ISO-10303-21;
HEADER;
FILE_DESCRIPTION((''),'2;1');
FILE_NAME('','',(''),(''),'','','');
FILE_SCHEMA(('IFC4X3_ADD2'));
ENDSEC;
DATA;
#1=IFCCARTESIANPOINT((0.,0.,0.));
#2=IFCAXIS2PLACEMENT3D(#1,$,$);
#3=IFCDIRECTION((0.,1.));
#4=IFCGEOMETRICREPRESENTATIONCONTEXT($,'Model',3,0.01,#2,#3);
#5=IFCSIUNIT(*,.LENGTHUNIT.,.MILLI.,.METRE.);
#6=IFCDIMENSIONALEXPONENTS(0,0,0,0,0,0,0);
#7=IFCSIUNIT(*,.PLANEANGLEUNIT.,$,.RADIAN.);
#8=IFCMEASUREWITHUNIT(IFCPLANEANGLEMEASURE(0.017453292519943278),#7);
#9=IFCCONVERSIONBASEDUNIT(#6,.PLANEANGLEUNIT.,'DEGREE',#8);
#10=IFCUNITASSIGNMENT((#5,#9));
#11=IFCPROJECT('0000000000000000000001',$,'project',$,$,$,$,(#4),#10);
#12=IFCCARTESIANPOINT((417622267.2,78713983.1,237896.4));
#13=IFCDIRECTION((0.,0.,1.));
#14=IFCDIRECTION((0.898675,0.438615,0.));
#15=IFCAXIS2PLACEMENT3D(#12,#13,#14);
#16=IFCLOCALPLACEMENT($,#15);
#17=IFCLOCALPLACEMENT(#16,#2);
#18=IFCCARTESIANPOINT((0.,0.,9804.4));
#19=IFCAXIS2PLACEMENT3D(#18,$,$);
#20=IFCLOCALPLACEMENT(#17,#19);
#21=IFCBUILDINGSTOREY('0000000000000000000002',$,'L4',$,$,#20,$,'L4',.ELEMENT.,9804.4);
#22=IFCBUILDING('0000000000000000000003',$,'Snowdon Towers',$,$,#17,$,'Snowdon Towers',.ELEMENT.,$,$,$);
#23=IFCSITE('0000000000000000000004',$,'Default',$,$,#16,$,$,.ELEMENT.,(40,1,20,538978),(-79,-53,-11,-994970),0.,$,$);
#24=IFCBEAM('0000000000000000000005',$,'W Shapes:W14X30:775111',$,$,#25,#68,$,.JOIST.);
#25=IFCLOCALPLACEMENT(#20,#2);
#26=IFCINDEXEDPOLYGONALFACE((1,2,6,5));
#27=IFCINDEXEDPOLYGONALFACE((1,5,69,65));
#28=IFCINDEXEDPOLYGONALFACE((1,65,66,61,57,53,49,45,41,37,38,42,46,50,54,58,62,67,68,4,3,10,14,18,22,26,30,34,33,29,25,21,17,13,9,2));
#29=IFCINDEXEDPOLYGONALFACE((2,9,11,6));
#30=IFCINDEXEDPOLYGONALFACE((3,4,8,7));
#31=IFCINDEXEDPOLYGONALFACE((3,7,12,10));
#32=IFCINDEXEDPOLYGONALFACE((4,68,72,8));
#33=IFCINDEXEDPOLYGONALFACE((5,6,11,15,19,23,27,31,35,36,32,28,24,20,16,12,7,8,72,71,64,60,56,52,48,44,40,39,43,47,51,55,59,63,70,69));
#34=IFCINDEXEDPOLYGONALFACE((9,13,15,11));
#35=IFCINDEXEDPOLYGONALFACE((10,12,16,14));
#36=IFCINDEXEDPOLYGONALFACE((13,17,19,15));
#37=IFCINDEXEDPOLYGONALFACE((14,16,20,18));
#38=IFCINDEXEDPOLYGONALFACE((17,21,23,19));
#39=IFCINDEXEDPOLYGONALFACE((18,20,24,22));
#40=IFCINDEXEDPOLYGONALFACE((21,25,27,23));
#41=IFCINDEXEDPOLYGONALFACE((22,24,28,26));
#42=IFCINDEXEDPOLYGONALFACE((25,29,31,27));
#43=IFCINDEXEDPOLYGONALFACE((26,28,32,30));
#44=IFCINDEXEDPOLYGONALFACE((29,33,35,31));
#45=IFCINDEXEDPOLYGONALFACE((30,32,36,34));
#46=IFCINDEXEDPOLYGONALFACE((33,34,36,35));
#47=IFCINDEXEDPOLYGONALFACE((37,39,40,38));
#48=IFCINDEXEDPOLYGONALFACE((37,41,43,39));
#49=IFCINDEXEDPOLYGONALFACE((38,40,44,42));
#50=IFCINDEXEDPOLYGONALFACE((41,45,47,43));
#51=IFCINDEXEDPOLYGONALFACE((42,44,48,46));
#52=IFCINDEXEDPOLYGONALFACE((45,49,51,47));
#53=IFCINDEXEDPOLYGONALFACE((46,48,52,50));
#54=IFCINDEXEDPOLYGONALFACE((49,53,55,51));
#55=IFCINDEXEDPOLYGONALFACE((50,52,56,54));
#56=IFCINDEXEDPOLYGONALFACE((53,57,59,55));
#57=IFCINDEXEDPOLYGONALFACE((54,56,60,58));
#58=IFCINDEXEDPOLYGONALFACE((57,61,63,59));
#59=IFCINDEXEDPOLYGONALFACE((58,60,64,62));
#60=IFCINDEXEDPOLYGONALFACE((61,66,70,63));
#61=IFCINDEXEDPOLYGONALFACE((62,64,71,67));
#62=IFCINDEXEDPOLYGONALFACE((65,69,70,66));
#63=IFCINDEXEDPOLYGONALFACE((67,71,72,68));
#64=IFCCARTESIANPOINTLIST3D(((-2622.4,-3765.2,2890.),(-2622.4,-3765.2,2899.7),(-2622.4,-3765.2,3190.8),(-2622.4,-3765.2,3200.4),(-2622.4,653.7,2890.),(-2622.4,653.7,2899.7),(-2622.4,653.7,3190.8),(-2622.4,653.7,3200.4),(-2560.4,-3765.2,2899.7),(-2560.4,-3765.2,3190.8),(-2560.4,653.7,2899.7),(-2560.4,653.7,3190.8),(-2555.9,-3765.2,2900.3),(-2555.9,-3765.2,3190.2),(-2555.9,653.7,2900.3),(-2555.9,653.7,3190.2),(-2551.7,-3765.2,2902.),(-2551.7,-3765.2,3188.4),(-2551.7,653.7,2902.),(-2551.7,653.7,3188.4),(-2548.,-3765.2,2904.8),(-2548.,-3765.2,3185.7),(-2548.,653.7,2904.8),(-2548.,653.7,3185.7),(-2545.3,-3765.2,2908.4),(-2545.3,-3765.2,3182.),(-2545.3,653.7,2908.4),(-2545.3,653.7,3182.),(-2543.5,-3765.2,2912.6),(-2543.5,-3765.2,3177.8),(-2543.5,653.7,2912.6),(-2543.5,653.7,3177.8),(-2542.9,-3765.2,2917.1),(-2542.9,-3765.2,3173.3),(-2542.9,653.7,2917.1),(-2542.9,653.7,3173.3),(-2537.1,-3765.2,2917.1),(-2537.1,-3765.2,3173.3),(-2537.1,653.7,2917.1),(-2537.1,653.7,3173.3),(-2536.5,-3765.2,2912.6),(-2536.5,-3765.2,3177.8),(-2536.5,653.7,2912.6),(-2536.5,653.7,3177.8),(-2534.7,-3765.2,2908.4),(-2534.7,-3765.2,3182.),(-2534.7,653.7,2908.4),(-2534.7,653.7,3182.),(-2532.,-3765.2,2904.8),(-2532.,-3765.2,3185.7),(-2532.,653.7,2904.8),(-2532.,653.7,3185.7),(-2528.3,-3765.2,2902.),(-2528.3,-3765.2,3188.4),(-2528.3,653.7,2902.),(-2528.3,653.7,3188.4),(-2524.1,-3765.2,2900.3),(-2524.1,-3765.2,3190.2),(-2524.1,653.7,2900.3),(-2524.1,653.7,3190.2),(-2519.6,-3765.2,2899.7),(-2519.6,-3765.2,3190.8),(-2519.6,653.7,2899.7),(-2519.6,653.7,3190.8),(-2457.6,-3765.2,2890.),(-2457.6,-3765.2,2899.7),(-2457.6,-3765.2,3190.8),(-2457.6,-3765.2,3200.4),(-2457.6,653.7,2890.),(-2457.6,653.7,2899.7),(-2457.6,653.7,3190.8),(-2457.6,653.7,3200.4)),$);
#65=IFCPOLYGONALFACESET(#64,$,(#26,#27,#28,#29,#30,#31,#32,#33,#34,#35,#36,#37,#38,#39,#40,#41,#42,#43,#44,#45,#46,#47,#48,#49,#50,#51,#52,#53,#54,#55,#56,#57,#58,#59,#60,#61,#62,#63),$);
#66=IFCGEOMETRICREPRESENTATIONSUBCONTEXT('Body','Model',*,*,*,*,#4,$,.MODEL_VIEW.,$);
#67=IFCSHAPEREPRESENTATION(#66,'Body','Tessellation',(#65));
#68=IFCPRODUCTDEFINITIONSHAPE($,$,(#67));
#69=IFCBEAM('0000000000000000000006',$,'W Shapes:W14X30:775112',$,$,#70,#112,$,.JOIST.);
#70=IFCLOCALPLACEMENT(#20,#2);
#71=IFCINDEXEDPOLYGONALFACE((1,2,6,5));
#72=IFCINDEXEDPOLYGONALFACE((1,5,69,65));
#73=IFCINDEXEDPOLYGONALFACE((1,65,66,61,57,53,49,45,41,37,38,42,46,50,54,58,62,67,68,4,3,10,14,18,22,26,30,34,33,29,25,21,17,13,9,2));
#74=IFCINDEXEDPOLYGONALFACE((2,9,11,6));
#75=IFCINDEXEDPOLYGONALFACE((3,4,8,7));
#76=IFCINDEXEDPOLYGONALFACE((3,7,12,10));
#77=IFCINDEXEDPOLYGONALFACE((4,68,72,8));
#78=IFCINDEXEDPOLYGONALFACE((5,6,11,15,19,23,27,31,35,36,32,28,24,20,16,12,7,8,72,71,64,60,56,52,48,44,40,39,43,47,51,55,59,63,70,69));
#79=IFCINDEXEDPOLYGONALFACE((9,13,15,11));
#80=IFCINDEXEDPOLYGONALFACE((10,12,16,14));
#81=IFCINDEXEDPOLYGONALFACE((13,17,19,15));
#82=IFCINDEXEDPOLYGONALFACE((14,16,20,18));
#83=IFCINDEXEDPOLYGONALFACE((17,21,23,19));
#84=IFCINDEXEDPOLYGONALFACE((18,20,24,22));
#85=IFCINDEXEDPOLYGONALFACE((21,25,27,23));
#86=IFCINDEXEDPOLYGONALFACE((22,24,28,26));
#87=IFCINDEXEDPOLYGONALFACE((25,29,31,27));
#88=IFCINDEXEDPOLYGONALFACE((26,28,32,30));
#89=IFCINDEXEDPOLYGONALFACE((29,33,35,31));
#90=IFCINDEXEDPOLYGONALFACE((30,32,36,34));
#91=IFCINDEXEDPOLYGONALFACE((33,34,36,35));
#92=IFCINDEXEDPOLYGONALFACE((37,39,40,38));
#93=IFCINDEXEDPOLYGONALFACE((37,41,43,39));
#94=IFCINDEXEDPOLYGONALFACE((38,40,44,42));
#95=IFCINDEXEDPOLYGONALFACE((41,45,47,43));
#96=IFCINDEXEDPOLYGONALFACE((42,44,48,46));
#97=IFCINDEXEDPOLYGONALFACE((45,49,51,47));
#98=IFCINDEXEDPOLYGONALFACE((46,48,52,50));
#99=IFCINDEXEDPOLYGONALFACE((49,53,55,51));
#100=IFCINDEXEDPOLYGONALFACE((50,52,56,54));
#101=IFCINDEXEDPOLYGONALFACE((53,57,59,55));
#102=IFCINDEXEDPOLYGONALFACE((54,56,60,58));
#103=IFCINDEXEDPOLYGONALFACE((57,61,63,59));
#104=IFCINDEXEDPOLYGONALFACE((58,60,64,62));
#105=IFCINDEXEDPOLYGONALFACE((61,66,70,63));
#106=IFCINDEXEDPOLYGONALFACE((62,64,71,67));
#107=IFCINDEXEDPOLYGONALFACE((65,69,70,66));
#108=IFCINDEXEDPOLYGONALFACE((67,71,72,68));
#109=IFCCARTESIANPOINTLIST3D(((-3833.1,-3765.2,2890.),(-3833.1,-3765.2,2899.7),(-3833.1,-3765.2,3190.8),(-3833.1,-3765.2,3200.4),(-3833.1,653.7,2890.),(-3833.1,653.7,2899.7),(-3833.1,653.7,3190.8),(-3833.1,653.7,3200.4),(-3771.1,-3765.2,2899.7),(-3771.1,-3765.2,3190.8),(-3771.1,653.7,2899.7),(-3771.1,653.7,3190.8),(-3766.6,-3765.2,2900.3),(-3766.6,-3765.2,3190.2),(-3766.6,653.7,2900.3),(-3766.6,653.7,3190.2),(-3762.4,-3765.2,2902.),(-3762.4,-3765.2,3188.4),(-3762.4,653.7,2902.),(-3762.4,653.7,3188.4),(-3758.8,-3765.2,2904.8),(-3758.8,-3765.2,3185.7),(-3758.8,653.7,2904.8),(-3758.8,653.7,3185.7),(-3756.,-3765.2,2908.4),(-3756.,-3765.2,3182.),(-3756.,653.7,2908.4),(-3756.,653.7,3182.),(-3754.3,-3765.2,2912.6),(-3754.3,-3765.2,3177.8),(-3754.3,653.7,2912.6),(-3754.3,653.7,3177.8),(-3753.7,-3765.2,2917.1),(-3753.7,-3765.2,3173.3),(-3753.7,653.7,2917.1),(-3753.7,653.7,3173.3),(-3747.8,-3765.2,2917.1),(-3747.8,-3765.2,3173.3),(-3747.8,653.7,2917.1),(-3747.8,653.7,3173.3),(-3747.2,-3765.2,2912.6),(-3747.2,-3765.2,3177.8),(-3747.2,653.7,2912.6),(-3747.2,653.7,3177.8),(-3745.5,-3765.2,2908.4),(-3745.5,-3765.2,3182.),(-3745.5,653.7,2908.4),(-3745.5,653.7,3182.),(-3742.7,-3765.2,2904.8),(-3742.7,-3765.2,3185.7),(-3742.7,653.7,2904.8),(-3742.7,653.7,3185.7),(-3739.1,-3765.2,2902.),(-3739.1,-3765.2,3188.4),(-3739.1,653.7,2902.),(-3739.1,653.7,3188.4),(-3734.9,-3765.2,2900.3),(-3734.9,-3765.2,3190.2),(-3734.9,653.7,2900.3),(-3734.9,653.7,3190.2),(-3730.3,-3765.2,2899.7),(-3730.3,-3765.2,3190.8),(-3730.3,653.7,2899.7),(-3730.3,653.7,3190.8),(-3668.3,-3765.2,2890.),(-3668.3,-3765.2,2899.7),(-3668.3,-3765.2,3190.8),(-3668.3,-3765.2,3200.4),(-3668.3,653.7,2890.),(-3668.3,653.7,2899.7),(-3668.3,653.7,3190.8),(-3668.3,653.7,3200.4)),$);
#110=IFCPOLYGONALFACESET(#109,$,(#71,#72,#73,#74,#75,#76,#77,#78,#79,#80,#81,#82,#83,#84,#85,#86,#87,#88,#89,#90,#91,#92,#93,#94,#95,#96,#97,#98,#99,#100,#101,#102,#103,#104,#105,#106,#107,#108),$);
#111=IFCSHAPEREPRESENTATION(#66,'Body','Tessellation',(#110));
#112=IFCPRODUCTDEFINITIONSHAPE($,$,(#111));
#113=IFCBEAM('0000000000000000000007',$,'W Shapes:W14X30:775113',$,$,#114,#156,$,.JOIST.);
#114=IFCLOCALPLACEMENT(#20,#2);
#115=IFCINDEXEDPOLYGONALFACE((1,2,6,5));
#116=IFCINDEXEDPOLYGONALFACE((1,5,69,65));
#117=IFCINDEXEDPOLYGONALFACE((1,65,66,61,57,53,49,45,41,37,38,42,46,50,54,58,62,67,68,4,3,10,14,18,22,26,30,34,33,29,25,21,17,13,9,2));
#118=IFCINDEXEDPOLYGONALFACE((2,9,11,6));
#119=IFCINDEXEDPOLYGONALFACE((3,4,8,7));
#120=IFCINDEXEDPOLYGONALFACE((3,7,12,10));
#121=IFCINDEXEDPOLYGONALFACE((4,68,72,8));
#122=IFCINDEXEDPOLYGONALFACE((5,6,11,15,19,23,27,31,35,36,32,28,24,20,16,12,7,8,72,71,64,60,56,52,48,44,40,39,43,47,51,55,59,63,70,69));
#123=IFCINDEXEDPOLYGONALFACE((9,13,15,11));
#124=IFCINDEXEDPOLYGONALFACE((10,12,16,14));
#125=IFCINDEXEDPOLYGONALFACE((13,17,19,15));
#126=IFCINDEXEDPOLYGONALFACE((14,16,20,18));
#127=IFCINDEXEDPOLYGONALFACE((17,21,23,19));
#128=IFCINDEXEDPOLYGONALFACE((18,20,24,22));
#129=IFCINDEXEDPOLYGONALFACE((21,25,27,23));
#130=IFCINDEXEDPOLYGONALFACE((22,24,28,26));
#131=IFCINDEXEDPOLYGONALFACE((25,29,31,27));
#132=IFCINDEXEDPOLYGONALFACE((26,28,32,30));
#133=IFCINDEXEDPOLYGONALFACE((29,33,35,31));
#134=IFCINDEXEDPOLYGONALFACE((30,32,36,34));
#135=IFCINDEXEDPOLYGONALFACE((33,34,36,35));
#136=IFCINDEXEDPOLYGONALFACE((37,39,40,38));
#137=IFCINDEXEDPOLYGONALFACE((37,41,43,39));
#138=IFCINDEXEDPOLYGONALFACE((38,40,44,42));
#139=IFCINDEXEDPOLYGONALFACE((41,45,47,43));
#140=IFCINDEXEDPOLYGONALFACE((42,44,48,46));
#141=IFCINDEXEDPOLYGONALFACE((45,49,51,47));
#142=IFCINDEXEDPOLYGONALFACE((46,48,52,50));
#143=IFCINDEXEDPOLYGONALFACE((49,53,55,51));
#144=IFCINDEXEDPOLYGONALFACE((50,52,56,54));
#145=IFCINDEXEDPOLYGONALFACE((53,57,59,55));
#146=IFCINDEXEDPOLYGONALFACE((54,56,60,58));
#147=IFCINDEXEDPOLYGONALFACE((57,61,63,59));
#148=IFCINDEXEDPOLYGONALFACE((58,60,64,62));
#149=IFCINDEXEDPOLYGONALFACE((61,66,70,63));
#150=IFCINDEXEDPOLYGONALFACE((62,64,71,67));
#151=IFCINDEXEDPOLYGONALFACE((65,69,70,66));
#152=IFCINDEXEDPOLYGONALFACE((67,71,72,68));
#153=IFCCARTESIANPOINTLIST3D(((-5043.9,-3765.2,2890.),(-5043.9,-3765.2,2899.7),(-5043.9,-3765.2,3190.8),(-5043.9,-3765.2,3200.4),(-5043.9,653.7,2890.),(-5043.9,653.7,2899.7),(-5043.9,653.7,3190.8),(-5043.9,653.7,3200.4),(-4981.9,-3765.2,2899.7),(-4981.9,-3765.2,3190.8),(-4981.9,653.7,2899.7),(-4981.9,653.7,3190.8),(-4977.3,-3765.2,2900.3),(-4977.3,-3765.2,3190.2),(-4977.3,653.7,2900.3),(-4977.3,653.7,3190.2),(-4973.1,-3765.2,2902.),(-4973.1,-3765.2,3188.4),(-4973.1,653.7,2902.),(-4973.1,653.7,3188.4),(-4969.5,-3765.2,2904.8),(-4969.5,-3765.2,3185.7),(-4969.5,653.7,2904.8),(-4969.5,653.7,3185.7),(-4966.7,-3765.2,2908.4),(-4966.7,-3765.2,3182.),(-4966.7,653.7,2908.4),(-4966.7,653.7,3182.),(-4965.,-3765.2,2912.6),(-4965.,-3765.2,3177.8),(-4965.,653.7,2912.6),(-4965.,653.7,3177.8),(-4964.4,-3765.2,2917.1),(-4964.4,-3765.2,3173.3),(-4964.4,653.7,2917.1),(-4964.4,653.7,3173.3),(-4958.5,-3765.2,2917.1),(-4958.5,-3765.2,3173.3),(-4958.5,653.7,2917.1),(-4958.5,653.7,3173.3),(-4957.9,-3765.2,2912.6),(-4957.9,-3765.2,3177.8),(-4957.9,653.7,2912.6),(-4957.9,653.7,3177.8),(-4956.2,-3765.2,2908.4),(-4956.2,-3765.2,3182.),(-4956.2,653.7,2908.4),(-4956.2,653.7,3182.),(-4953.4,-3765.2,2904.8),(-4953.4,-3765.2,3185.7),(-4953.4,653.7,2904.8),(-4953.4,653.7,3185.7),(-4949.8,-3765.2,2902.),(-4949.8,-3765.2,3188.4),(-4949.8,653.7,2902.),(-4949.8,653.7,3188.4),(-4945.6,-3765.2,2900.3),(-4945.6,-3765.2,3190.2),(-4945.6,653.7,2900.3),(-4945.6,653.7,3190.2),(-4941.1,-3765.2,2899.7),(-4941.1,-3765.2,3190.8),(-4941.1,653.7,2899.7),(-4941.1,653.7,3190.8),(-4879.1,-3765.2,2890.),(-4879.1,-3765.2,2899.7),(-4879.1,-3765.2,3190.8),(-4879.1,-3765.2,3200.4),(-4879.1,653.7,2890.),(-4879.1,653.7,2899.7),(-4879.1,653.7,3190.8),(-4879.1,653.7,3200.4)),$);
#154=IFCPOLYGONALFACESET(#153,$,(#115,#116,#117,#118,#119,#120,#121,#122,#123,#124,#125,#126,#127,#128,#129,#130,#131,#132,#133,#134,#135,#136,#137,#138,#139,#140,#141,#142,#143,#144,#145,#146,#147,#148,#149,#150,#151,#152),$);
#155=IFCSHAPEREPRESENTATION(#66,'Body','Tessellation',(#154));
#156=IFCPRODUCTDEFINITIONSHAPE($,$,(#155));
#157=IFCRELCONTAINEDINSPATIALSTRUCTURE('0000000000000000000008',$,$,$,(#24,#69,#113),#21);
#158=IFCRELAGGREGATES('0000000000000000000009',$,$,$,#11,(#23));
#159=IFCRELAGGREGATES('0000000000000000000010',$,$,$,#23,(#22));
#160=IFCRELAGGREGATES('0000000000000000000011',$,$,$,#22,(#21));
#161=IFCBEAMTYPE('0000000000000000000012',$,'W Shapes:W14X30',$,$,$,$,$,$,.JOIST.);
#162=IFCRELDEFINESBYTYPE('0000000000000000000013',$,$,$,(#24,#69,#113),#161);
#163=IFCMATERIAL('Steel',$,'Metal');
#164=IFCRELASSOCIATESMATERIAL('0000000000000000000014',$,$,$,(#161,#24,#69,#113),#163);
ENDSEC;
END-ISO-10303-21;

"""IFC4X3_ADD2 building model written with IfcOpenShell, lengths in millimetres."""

from ifc_helpers import new_model, entity, si_unit, converted_unit, direction, frame, frame_2d, origin, place, context, subcontext, project, spatial, polyline, circle_curve, parameter, trimmed, segment, composite_curve, outline, extrude, source, transform, mapped, material, material_profile, profile_set, profile_usage, type_object, type_shapes, element, save


model = new_model("IFC4X3_ADD2")

# Units and contexts
model_context = context("Model", 3, precision=0.01, world=origin(), true_north=direction((0.0, 1.0)))
body_context = subcontext(model_context, "Body", "Model", "MODEL_VIEW")
ifc_project = project(units=[si_unit("LENGTHUNIT", "METRE", prefix="MILLI"), converted_unit("PLANEANGLEUNIT", "DEGREE", entity("IfcPlaneAngleMeasure", 0.017453292519943278), si_unit("PLANEANGLEUNIT", "RADIAN"), dimensions=[0, 0, 0, 0, 0, 0, 0])], contexts=[model_context])

# Site, building, storey
site_placement = place(None, frame((417622267.2, 78713983.1, 237896.4), z_axis=(0.0, 0.0, 1.0), x_axis=(0.898675, 0.438615, 0.0)))
site = spatial("IfcSite", under=ifc_project, at=site_placement, Name="Default", CompositionType="ELEMENT", RefLatitude=(40, 1, 20, 538978), RefLongitude=(-79, -53, -11, -994970), RefElevation=0.0)
building_placement = place(site_placement, origin())
building = spatial("IfcBuilding", under=site, at=building_placement, Name="Snowdon Towers", LongName="Snowdon Towers", CompositionType="ELEMENT")
storey_placement = place(building_placement, frame((0.0, 0.0, 9804.4)))
storey = spatial("IfcBuildingStorey", under=building, at=storey_placement, Name="L4", LongName="L4", CompositionType="ELEMENT", Elevation=9804.4)

# Shared definitions
ifc_material_1 = material(Name="Steel", Category="Metal")

# Beams
ifc_material_profile_1 = material_profile(ifc_material_1, outline(composite_curve([segment(polyline([(-82.4, -145.6), (-82.4, -155.2)]), True, "CONTINUOUS"), segment(polyline([(-82.4, -155.2), (82.4, -155.2)]), True, "CONTINUOUS"), segment(polyline([(82.4, -155.2), (82.4, -145.6)]), True, "CONTINUOUS"), segment(polyline([(82.4, -145.6), (20.4, -145.6)]), True, "CONTINUOUS"), segment(trimmed(circle_curve(frame_2d((20.4, -128.1), x_axis=(1.0, 0.0)), 17.5), [parameter(180.0)], [parameter(270.0)], True, "PARAMETER"), False, "CONTINUOUS"), segment(polyline([(2.9, -128.1), (2.9, 128.1)]), True, "CONTINUOUS"), segment(trimmed(circle_curve(frame_2d((20.4, 128.1), x_axis=(1.0, 0.0)), 17.5), [parameter(90.0)], [parameter(180.0)], True, "PARAMETER"), False, "CONTINUOUS"), segment(polyline([(20.4, 145.6), (82.4, 145.6)]), True, "CONTINUOUS"), segment(polyline([(82.4, 145.6), (82.4, 155.2)]), True, "CONTINUOUS"), segment(polyline([(82.4, 155.2), (-82.4, 155.2)]), True, "CONTINUOUS"), segment(polyline([(-82.4, 155.2), (-82.4, 145.6)]), True, "CONTINUOUS"), segment(polyline([(-82.4, 145.6), (-20.4, 145.6)]), True, "CONTINUOUS"), segment(trimmed(circle_curve(frame_2d((-20.4, 128.1), x_axis=(1.0, 0.0)), 17.5), [parameter(360.0)], [parameter(90.0)], True, "PARAMETER"), False, "CONTINUOUS"), segment(polyline([(-2.9, 128.1), (-2.9, -128.1)]), True, "CONTINUOUS"), segment(trimmed(circle_curve(frame_2d((-20.4, -128.1), x_axis=(1.0, 0.0)), 17.5), [parameter(270.0)], [parameter(360.0)], True, "PARAMETER"), False, "CONTINUOUS"), segment(polyline([(-20.4, -145.6), (-82.4, -145.6)]), True, "CONTINUOUS")], self_intersect=False)), Name="W14X30")
ifc_profile_set_1 = profile_set([ifc_material_profile_1], Name="W14X30")
ifc_profile_usage_1 = profile_usage(ifc_profile_set_1, cardinal=8)
beam_type_1 = type_object("IfcBeamType", Name="W Shapes:W14X30", PredefinedType="JOIST", material=ifc_profile_set_1)
shared_shape_1 = source(origin(), body_context, "Body", "SweptSolid", [
    extrude(outline(composite_curve([segment(polyline([(-82.4, -145.6), (-82.4, -155.2)]), True, "CONTINUOUS"), segment(polyline([(-82.4, -155.2), (82.4, -155.2)]), True, "CONTINUOUS"), segment(polyline([(82.4, -155.2), (82.4, -145.6)]), True, "CONTINUOUS"), segment(polyline([(82.4, -145.6), (20.4, -145.6)]), True, "CONTINUOUS"), segment(trimmed(circle_curve(frame_2d((20.4, -128.1), x_axis=(1.0, 0.0)), 17.5), [parameter(180.0)], [parameter(270.0)], True, "PARAMETER"), False, "CONTINUOUS"), segment(polyline([(2.9, -128.1), (2.9, 128.1)]), True, "CONTINUOUS"), segment(trimmed(circle_curve(frame_2d((20.4, 128.1), x_axis=(1.0, 0.0)), 17.5), [parameter(90.0)], [parameter(180.0)], True, "PARAMETER"), False, "CONTINUOUS"), segment(polyline([(20.4, 145.6), (82.4, 145.6)]), True, "CONTINUOUS"), segment(polyline([(82.4, 145.6), (82.4, 155.2)]), True, "CONTINUOUS"), segment(polyline([(82.4, 155.2), (-82.4, 155.2)]), True, "CONTINUOUS"), segment(polyline([(-82.4, 155.2), (-82.4, 145.6)]), True, "CONTINUOUS"), segment(polyline([(-82.4, 145.6), (-20.4, 145.6)]), True, "CONTINUOUS"), segment(trimmed(circle_curve(frame_2d((-20.4, 128.1), x_axis=(1.0, 0.0)), 17.5), [parameter(360.0)], [parameter(90.0)], True, "PARAMETER"), False, "CONTINUOUS"), segment(polyline([(-2.9, 128.1), (-2.9, -128.1)]), True, "CONTINUOUS"), segment(trimmed(circle_curve(frame_2d((-20.4, -128.1), x_axis=(1.0, 0.0)), 17.5), [parameter(270.0)], [parameter(360.0)], True, "PARAMETER"), False, "CONTINUOUS"), segment(polyline([(-20.4, -145.6), (-82.4, -145.6)]), True, "CONTINUOUS")], self_intersect=False)), frame((-2209.4, 0.0, 0.0), z_axis=(-1.0, 0.0, 0.0), x_axis=(0.0, -1.0, 0.0)), (0.0, 0.0, -1.0), 4418.8),
])
type_shapes(beam_type_1, [shared_shape_1])
for number, where, z_axis, x_axis, name in (
    (1, (-2540.0, -1555.8, 3045.2), (0.0, 0.0, 1.0), (0.0, -1.0, 0.0), "W Shapes:W14X30:775111"),
    (2, (-3750.7, -1555.8, 3045.2), (0.0, 0.0, 1.0), (0.0, -1.0, 0.0), "W Shapes:W14X30:775112"),
    (3, (-4961.5, -1555.8, 3045.2), (0.0, 0.0, 1.0), (0.0, -1.0, 0.0), "W Shapes:W14X30:775113"),
):
    element("IfcBeam", number, at=place(storey_placement, frame(where, z_axis=z_axis, x_axis=x_axis)), inside=storey, type_object=beam_type_1, material=ifc_profile_usage_1, Name=name, PredefinedType="JOIST", context=body_context, shape_type="MappedRepresentation", body=[
        mapped(shared_shape_1, transform((0.0, 0.0, 0.0), scale=1.0)),
    ])

save(model, "model.ifc")
